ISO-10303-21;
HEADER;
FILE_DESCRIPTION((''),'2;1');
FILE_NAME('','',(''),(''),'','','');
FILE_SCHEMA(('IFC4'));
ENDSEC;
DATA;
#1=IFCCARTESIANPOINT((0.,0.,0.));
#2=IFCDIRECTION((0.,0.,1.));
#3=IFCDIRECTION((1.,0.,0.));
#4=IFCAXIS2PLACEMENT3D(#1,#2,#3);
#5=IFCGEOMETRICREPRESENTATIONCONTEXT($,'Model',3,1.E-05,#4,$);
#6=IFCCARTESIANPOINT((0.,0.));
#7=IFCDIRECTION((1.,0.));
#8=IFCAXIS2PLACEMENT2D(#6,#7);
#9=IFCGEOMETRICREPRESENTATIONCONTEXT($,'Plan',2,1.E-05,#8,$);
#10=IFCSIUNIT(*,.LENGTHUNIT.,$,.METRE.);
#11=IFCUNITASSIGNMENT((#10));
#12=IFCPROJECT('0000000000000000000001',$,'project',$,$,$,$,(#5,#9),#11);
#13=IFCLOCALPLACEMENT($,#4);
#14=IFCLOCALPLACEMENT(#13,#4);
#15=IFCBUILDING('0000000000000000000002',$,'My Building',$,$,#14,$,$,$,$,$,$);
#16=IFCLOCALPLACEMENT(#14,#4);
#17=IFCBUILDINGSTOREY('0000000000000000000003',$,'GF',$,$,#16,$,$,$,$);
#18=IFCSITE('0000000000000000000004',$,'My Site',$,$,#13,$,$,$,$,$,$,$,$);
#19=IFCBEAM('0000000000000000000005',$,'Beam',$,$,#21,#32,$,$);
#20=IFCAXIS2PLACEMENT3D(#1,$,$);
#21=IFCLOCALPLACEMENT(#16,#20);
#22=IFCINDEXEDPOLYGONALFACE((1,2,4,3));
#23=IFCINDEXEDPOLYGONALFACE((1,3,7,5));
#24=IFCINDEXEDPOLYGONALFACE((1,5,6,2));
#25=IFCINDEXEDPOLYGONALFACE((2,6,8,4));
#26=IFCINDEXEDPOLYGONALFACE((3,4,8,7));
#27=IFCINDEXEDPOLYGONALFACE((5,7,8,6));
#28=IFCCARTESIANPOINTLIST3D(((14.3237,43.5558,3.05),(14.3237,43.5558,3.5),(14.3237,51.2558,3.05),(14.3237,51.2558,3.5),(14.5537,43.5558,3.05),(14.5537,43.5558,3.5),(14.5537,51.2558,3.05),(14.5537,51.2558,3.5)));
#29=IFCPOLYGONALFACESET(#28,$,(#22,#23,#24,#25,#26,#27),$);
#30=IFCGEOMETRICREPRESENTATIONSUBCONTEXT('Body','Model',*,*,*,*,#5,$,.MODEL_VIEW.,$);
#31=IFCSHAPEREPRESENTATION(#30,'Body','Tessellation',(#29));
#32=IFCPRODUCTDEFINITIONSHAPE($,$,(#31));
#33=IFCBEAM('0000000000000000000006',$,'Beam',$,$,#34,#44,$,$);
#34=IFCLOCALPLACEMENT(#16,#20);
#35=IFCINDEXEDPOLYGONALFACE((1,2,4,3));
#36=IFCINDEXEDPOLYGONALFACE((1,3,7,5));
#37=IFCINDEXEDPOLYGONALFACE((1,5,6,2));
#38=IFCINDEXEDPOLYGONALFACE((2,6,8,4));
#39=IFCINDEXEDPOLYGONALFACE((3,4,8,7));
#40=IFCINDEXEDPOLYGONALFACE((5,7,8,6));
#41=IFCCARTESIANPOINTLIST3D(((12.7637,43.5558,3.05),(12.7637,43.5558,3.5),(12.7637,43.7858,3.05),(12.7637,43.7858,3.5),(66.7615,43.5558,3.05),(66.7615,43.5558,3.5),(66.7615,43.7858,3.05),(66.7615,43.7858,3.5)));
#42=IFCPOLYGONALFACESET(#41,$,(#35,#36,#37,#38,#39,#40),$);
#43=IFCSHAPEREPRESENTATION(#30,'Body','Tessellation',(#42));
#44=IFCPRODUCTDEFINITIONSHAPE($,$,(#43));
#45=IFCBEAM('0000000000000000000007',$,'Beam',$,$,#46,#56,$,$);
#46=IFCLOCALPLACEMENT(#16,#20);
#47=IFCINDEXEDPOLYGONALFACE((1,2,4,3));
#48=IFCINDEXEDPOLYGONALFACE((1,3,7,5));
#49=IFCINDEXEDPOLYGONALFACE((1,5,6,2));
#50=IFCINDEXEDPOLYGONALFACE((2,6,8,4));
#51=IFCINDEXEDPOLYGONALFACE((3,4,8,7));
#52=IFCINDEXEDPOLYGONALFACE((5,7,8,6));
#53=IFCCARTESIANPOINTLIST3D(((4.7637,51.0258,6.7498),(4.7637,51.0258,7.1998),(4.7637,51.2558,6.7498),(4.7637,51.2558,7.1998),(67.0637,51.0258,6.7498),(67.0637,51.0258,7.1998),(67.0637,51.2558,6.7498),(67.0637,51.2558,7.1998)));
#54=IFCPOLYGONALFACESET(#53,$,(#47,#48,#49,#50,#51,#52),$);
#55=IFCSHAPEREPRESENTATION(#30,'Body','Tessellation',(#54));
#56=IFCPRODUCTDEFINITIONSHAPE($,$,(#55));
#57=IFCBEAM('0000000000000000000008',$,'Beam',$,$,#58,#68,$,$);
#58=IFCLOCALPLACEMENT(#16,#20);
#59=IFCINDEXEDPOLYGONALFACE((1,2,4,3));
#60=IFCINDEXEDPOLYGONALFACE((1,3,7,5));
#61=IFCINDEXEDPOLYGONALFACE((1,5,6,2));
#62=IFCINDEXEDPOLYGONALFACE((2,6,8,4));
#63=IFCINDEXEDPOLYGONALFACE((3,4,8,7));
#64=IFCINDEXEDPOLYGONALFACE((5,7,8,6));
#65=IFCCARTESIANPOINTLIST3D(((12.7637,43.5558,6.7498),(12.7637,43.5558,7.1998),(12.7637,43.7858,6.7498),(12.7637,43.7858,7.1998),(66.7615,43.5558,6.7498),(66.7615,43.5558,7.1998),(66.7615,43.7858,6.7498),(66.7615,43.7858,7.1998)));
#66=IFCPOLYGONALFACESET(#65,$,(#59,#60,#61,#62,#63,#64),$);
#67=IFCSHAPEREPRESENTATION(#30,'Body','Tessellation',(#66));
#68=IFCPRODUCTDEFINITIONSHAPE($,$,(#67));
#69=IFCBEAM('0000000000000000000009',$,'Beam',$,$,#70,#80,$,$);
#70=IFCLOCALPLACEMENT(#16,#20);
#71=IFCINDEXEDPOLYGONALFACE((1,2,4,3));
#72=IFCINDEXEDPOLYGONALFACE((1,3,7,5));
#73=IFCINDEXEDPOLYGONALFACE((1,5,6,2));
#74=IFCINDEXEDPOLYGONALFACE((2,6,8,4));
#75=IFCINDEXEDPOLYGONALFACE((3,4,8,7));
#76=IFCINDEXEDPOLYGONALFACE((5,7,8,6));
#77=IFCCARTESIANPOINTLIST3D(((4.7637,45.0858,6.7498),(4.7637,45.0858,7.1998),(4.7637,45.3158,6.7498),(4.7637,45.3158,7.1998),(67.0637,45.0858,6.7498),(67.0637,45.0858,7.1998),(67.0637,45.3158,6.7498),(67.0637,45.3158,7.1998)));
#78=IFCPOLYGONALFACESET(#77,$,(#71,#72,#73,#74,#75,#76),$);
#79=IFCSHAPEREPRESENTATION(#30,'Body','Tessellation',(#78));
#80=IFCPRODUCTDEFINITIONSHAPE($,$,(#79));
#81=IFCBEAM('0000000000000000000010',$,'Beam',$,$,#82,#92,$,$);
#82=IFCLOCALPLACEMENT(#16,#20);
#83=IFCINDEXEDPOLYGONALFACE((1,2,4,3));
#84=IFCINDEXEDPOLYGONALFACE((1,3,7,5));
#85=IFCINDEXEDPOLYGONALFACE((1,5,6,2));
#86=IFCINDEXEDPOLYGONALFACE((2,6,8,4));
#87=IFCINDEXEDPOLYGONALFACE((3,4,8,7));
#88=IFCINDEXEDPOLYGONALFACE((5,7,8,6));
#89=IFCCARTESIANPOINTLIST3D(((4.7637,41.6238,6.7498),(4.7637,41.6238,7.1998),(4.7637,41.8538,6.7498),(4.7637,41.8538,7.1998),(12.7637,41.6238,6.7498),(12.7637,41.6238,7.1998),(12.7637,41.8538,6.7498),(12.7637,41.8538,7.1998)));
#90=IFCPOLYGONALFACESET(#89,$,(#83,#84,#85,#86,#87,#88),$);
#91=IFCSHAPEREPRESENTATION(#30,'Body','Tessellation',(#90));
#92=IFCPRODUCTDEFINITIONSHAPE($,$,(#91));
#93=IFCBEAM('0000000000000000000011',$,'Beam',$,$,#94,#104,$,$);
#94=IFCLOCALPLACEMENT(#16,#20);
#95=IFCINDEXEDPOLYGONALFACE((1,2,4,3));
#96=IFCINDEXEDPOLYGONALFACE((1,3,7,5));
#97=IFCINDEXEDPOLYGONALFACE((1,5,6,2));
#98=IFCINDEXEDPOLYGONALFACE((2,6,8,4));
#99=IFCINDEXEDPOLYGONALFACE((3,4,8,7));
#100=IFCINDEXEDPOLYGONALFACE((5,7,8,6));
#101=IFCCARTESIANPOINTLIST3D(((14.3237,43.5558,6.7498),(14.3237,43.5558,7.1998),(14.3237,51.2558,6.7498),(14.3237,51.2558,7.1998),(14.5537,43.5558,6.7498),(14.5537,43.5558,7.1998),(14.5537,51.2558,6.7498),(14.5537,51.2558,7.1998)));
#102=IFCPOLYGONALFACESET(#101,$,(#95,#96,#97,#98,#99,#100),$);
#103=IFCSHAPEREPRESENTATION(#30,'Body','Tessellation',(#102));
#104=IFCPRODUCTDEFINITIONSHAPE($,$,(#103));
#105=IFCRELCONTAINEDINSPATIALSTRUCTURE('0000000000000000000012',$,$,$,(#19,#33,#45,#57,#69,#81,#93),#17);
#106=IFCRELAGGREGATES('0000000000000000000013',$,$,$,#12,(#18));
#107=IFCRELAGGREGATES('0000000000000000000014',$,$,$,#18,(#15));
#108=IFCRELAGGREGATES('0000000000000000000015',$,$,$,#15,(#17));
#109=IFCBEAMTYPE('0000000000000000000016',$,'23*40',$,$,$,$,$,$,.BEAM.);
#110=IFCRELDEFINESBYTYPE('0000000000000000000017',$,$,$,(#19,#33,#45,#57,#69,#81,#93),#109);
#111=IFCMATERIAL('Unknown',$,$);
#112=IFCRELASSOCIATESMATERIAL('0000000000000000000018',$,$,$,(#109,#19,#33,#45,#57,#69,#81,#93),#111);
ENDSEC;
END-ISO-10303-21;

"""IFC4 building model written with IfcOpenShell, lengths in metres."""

from ifc_helpers import new_model, si_unit, frame, origin_with_axes, origin_2d_with_axis, place, context, subcontext, project, spatial, rectangle, extrude, material, material_profile, profile_set, profile_usage, type_object, element, save


model = new_model("IFC4")

# Units and contexts
model_context = context("Model", 3, precision=1e-05, world=origin_with_axes())
plan_context = context("Plan", 2, precision=1e-05, world=origin_2d_with_axis())
body_context = subcontext(model_context, "Body", "Model", "MODEL_VIEW")
ifc_project = project(units=[si_unit("LENGTHUNIT", "METRE")], contexts=[model_context, plan_context])

# Site, building, storey
site_placement = place(None, origin_with_axes())
site = spatial("IfcSite", under=ifc_project, at=site_placement, Name="My Site")
building_placement = place(site_placement, origin_with_axes())
building = spatial("IfcBuilding", under=site, at=building_placement, Name="My Building")
storey_placement = place(building_placement, origin_with_axes())
storey = spatial("IfcBuildingStorey", under=building, at=storey_placement, Name="GF")

# Shared definitions
ifc_material = material(Name="Unknown")

# Beams
ifc_material_profile_1 = material_profile(ifc_material, rectangle(XDim=0.23, YDim=0.45))
ifc_profile_set_1 = profile_set([ifc_material_profile_1])
beam_type = type_object("IfcBeamType", Name="23*40", PredefinedType="BEAM", material=ifc_profile_set_1)
ifc_profile_usage_1 = profile_usage(ifc_profile_set_1, cardinal=5)
beam_1_placement = place(storey_placement, frame((14.4387, 43.5558, 3.275), z_axis=(0.0, 1.0, 0.0), x_axis=(-1.0, 0.0, 0.0)))
element("IfcBeam", 1, at=beam_1_placement, inside=storey, type_object=beam_type, material=ifc_profile_usage_1, Name="Beam", context=body_context, shape_type="SweptSolid", body=[
    extrude(rectangle(XDim=0.23, YDim=0.45), origin_with_axes(), (0.0, 0.0, 1.0), 7.7),
])
ifc_profile_usage_2 = profile_usage(ifc_profile_set_1, cardinal=5)
beam_2_placement = place(storey_placement, frame((12.7637, 43.6708, 3.275), z_axis=(1.0, 0.0, 0.0), x_axis=(0.0, 1.0, 0.0)))
element("IfcBeam", 2, at=beam_2_placement, inside=storey, type_object=beam_type, material=ifc_profile_usage_2, Name="Beam", context=body_context, shape_type="SweptSolid", body=[
    extrude(rectangle(XDim=0.23, YDim=0.45), origin_with_axes(), (0.0, 0.0, 1.0), 53.9978),
])
ifc_profile_usage_3 = profile_usage(ifc_profile_set_1, cardinal=5)
beam_3_placement = place(storey_placement, frame((4.7637, 51.1408, 6.9748), z_axis=(1.0, 0.0, 0.0), x_axis=(0.0, 1.0, 0.0)))
element("IfcBeam", 3, at=beam_3_placement, inside=storey, type_object=beam_type, material=ifc_profile_usage_3, Name="Beam", context=body_context, shape_type="SweptSolid", body=[
    extrude(rectangle(XDim=0.23, YDim=0.45), origin_with_axes(), (0.0, 0.0, 1.0), 62.3),
])
ifc_profile_usage_4 = profile_usage(ifc_profile_set_1, cardinal=5)
beam_4_placement = place(storey_placement, frame((12.7637, 43.6708, 6.9748), z_axis=(1.0, 0.0, 0.0), x_axis=(0.0, 1.0, 0.0)))
element("IfcBeam", 4, at=beam_4_placement, inside=storey, type_object=beam_type, material=ifc_profile_usage_4, Name="Beam", context=body_context, shape_type="SweptSolid", body=[
    extrude(rectangle(XDim=0.23, YDim=0.45), origin_with_axes(), (0.0, 0.0, 1.0), 53.9978),
])
ifc_profile_usage_5 = profile_usage(ifc_profile_set_1, cardinal=5)
beam_5_placement = place(storey_placement, frame((4.7637, 45.2008, 6.9748), z_axis=(1.0, 0.0, 0.0), x_axis=(0.0, 1.0, 0.0)))
element("IfcBeam", 5, at=beam_5_placement, inside=storey, type_object=beam_type, material=ifc_profile_usage_5, Name="Beam", context=body_context, shape_type="SweptSolid", body=[
    extrude(rectangle(XDim=0.23, YDim=0.45), origin_with_axes(), (0.0, 0.0, 1.0), 62.3),
])
ifc_profile_usage_6 = profile_usage(ifc_profile_set_1, cardinal=5)
beam_6_placement = place(storey_placement, frame((4.7637, 41.7388, 6.9748), z_axis=(1.0, 0.0, 0.0), x_axis=(0.0, 1.0, 0.0)))
element("IfcBeam", 6, at=beam_6_placement, inside=storey, type_object=beam_type, material=ifc_profile_usage_6, Name="Beam", context=body_context, shape_type="SweptSolid", body=[
    extrude(rectangle(XDim=0.23, YDim=0.45), origin_with_axes(), (0.0, 0.0, 1.0), 8.0),
])
ifc_profile_usage_7 = profile_usage(ifc_profile_set_1, cardinal=5)
beam_7_placement = place(storey_placement, frame((14.4387, 43.5558, 6.9748), z_axis=(0.0, 1.0, 0.0), x_axis=(-1.0, 0.0, 0.0)))
element("IfcBeam", 7, at=beam_7_placement, inside=storey, type_object=beam_type, material=ifc_profile_usage_7, Name="Beam", context=body_context, shape_type="SweptSolid", body=[
    extrude(rectangle(XDim=0.23, YDim=0.45), origin_with_axes(), (0.0, 0.0, 1.0), 7.7),
])

save(model, "model.ifc")
